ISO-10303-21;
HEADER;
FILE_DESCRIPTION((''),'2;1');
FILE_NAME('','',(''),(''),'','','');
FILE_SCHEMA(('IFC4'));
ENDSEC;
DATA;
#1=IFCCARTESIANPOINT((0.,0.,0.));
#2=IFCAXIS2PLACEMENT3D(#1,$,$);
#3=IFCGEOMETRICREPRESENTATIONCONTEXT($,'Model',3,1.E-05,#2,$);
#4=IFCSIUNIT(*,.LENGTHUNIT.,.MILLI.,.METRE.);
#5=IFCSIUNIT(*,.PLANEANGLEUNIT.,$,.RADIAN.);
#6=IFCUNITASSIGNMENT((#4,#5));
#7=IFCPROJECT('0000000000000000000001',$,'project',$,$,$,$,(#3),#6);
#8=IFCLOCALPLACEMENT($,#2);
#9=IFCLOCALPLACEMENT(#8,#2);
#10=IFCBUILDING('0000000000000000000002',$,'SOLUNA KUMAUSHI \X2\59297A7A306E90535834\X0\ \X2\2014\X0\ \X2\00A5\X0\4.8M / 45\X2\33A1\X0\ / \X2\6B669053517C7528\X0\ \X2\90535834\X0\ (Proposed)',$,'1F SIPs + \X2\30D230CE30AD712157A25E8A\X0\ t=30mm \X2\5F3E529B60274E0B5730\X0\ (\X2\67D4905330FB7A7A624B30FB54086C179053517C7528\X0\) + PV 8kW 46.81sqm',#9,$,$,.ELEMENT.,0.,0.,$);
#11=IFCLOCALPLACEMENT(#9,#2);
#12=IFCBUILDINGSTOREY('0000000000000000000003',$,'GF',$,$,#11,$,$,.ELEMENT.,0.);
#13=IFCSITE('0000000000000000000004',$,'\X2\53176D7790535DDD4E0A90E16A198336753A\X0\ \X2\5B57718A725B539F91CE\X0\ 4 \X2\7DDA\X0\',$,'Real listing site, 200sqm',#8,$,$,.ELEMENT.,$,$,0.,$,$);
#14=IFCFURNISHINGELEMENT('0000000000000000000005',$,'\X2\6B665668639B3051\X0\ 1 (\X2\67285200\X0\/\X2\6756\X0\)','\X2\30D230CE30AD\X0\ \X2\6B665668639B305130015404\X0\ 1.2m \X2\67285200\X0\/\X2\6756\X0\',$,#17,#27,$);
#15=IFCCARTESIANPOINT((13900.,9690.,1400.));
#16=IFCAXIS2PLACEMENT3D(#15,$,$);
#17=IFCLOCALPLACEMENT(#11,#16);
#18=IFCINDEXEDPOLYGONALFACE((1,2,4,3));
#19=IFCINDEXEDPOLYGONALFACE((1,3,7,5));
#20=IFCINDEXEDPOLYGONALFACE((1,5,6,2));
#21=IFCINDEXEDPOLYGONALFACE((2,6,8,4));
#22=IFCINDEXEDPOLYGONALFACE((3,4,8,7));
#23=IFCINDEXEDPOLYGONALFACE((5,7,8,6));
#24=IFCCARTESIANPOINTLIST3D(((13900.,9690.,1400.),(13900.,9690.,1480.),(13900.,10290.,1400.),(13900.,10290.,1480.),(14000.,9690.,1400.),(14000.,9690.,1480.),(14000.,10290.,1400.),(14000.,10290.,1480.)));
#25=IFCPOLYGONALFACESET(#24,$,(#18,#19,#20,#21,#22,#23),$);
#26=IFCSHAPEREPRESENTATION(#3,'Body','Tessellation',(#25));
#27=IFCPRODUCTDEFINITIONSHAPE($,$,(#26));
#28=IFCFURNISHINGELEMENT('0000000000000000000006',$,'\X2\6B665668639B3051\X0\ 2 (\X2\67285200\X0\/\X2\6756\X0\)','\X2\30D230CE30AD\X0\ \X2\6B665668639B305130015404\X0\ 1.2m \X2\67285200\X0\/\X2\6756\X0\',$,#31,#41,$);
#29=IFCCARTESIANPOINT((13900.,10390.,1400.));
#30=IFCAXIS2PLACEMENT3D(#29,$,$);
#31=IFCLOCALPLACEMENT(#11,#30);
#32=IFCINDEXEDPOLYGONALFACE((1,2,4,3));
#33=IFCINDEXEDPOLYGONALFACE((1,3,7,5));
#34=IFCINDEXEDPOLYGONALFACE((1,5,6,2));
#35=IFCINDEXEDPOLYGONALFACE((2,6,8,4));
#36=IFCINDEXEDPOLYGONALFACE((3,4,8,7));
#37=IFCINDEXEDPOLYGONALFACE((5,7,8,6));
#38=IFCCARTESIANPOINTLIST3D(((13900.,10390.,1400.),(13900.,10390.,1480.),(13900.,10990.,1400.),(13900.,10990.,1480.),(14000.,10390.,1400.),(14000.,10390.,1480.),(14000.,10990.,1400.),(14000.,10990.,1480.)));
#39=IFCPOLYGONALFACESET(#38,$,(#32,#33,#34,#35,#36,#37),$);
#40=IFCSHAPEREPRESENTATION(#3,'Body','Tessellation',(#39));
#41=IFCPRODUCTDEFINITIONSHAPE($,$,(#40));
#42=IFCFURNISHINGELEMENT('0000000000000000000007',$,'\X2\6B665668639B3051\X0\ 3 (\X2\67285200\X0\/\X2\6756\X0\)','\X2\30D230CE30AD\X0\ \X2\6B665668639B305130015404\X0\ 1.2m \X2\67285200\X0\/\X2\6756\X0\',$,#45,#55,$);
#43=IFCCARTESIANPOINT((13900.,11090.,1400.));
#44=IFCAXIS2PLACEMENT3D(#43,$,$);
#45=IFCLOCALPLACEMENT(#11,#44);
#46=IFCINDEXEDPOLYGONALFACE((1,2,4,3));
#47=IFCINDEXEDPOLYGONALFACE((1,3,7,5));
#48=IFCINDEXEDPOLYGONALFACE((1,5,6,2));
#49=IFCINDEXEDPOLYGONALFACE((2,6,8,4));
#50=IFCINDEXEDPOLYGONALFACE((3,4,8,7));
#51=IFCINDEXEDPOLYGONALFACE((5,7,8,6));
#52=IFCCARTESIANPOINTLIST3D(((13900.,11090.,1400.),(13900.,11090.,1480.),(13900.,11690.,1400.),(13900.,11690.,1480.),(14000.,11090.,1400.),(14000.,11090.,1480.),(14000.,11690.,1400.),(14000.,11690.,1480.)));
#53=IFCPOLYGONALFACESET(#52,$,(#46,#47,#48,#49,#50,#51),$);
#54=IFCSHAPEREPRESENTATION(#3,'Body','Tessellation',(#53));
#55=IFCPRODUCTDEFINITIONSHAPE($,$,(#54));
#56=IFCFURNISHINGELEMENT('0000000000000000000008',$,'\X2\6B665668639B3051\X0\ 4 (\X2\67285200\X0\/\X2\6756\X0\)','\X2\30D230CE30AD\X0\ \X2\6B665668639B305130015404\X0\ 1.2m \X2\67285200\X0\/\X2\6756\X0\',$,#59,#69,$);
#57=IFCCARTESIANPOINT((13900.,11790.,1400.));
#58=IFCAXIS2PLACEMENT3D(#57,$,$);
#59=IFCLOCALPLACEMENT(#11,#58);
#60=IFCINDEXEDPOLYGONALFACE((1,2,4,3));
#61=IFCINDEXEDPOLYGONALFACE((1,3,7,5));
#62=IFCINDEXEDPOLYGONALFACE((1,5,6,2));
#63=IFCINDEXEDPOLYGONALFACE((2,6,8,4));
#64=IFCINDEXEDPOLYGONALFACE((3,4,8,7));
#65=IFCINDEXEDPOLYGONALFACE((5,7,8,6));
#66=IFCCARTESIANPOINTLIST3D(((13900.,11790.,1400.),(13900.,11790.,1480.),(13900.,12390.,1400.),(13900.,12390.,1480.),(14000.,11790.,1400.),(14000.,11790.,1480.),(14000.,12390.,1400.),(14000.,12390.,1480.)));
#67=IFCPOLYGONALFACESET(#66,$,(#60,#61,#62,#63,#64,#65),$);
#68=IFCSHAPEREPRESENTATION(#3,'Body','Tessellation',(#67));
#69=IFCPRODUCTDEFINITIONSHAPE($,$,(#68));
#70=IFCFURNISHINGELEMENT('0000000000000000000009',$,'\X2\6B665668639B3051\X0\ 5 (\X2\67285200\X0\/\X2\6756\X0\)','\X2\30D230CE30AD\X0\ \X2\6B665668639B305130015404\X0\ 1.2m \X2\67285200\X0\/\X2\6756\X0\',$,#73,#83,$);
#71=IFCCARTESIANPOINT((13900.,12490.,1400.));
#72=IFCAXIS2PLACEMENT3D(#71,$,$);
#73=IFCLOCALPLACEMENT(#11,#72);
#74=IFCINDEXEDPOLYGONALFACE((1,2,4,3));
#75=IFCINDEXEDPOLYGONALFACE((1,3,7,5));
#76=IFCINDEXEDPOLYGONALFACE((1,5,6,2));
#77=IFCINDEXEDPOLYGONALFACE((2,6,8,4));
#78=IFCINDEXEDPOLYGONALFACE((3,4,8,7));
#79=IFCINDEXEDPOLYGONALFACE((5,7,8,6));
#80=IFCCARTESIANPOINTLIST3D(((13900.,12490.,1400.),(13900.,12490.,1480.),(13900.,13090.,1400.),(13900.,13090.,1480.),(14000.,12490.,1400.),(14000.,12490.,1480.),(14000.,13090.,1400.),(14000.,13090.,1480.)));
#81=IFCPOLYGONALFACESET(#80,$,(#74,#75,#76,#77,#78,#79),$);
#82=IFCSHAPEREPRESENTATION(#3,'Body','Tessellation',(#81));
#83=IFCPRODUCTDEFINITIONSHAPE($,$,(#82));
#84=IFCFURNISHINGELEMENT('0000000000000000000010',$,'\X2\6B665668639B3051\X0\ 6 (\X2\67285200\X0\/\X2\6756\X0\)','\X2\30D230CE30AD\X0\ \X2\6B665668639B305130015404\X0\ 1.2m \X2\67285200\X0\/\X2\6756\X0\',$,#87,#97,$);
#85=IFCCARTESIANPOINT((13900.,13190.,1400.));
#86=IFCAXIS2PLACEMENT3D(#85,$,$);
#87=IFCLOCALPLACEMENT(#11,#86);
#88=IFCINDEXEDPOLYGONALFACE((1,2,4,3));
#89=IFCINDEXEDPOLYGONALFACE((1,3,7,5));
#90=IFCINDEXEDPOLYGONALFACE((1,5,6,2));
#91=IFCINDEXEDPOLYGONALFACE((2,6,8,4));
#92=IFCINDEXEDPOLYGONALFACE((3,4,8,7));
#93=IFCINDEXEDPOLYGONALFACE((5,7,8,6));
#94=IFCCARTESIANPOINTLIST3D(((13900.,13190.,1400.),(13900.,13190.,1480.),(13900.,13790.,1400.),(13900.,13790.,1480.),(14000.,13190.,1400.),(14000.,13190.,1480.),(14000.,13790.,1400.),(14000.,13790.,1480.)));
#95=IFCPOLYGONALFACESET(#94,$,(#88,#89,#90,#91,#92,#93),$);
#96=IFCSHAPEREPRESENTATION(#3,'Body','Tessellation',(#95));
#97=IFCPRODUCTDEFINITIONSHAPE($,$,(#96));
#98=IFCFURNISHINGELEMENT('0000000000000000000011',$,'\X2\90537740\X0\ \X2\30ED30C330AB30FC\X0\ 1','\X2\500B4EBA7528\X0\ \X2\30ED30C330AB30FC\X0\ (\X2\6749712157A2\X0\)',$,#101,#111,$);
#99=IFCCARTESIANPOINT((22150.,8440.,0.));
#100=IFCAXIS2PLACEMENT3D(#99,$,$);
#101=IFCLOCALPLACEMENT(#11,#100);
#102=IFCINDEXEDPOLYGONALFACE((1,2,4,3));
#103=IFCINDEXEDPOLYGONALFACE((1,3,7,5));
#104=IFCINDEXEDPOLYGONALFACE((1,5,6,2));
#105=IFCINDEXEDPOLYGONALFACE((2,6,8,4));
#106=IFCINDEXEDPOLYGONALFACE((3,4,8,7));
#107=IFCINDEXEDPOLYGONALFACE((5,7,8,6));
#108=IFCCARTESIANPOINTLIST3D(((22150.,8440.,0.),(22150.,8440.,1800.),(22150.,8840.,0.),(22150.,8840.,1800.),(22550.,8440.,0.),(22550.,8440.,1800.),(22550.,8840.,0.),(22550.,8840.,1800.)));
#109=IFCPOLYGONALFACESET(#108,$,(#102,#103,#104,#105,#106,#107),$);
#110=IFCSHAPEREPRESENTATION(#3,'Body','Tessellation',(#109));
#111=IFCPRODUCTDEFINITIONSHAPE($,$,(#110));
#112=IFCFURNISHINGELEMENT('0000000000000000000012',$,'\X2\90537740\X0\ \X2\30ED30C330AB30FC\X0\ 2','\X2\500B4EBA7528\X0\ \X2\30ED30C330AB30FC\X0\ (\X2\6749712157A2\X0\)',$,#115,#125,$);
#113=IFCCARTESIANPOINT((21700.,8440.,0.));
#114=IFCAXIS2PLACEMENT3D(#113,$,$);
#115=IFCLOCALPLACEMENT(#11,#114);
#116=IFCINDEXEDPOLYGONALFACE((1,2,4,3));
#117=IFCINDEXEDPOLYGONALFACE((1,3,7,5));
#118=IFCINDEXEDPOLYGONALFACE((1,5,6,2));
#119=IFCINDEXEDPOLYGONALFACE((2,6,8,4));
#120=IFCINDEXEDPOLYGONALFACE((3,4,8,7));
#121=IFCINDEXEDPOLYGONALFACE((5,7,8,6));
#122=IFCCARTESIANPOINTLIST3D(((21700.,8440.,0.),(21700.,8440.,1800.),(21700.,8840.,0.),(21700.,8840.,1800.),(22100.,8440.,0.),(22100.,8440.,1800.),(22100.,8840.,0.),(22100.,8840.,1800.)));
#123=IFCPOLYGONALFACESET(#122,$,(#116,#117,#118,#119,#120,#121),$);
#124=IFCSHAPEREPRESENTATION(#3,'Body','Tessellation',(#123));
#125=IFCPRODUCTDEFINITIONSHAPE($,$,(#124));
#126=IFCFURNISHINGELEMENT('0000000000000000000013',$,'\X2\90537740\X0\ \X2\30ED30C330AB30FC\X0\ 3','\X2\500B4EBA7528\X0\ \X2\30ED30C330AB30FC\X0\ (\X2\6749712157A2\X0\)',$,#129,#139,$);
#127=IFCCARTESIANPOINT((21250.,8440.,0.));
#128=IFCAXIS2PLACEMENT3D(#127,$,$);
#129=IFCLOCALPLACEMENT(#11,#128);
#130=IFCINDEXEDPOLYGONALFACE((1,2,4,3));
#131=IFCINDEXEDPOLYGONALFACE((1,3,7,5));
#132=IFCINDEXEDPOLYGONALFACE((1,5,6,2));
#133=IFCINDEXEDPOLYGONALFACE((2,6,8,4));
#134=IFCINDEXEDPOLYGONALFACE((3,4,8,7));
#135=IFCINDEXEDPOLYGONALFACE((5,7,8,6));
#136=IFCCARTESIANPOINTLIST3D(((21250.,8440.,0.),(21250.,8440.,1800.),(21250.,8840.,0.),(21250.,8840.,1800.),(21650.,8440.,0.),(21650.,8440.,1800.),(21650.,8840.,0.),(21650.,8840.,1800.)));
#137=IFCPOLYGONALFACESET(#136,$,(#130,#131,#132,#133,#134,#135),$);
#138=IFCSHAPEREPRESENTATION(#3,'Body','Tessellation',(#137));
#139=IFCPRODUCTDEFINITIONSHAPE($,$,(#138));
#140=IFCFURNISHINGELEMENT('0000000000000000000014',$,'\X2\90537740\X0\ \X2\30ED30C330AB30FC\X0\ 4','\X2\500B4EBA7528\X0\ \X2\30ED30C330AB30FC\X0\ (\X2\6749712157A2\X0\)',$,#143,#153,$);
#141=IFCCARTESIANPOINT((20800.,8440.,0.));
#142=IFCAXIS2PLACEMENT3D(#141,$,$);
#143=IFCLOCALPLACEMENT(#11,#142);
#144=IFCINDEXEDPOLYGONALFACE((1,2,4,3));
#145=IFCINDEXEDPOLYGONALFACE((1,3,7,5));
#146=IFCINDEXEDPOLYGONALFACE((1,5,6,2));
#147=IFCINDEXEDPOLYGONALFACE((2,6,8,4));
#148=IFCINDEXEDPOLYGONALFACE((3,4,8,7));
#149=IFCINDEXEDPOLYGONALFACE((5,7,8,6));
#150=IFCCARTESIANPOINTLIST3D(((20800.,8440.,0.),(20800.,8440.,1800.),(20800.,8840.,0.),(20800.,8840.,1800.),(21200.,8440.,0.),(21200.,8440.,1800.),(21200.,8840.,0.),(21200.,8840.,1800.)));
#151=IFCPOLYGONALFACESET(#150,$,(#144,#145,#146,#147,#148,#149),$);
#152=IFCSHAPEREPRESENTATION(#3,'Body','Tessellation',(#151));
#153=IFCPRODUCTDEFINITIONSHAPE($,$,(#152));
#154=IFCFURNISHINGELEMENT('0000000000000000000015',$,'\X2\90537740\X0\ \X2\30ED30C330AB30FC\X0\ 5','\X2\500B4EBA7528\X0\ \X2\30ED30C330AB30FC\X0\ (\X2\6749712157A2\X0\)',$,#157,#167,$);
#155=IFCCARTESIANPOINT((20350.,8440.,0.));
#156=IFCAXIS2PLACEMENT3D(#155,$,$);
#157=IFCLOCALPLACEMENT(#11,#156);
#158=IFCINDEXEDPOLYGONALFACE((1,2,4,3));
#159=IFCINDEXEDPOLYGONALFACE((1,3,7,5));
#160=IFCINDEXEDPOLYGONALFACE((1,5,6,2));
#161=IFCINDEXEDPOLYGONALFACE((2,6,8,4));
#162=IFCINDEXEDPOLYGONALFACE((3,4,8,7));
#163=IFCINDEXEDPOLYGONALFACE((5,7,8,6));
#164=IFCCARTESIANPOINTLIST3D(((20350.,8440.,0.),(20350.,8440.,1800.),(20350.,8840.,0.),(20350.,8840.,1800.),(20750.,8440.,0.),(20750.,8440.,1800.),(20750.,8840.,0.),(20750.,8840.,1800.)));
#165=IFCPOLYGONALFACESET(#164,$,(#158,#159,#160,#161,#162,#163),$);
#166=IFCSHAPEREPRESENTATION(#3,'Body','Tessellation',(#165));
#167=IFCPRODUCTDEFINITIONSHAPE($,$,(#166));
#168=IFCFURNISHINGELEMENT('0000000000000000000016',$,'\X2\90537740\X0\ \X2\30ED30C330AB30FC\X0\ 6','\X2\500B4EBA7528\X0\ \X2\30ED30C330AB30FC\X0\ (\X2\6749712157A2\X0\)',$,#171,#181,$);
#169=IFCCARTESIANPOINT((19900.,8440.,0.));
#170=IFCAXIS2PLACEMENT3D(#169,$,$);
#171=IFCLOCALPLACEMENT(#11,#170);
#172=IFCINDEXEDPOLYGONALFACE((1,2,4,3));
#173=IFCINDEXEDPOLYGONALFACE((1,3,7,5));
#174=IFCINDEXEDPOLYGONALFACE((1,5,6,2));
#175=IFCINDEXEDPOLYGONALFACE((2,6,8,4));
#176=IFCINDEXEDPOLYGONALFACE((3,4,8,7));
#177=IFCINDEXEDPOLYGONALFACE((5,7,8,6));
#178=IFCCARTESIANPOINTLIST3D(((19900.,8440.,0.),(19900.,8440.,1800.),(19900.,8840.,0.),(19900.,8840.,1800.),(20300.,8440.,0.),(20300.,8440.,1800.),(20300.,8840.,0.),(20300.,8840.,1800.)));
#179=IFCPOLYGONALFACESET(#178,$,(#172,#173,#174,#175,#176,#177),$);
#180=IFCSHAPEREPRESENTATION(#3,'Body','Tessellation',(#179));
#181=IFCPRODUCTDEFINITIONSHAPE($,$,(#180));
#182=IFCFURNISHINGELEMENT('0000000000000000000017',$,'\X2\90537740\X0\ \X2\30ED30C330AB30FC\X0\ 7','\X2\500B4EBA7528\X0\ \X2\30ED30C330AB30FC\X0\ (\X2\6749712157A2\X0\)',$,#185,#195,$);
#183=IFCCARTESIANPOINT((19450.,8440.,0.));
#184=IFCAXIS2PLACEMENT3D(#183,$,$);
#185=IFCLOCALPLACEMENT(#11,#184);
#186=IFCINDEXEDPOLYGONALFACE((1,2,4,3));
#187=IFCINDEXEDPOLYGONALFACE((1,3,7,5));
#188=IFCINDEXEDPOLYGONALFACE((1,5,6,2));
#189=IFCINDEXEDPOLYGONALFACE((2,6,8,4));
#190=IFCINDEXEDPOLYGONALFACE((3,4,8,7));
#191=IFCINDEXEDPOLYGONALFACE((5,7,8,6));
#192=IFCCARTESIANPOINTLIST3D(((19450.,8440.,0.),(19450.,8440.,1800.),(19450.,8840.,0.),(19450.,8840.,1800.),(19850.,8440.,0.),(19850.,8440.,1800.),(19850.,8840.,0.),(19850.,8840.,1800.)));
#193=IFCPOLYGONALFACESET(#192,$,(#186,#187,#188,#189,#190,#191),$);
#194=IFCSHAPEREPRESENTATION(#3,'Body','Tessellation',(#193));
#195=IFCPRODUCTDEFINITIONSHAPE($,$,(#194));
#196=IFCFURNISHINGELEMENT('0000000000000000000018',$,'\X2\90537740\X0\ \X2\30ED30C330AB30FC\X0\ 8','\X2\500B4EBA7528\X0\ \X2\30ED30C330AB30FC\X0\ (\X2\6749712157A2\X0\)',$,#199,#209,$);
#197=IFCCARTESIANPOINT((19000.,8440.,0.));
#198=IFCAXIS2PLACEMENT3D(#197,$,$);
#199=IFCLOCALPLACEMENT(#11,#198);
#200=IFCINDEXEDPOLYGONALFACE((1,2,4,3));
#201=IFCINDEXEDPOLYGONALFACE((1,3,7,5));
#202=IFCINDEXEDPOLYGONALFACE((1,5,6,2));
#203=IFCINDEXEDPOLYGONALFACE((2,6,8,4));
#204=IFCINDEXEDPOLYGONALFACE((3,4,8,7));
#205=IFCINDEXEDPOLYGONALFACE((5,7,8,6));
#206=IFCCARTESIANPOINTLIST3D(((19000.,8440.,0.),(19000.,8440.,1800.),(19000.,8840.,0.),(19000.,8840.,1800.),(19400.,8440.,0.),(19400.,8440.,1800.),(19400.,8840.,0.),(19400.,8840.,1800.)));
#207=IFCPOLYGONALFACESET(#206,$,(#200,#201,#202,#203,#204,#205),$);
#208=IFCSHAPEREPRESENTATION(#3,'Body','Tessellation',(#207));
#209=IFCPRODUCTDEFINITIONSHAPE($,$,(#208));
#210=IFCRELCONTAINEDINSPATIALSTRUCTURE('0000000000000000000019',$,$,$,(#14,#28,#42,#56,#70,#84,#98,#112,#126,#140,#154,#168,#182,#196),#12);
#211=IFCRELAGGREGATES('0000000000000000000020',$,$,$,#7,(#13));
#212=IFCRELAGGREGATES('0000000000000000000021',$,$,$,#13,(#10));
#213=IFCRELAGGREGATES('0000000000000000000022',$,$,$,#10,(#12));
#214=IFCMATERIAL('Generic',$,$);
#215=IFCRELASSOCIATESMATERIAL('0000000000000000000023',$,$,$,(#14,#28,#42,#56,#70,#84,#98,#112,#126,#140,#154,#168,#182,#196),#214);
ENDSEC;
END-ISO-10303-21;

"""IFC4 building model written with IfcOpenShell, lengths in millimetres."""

from ifc_helpers import new_model, si_unit, frame, frame_2d, origin, place, context, project, spatial, rectangle, extrude, material, element, save


model = new_model("IFC4")

# Units and contexts
model_context = context("Model", 3, precision=1e-05, world=origin())
ifc_project = project(units=[si_unit("LENGTHUNIT", "METRE", prefix="MILLI"), si_unit("PLANEANGLEUNIT", "RADIAN")], contexts=[model_context])

# Site, building, storey
site_placement = place(None, origin())
site = spatial("IfcSite", under=ifc_project, at=site_placement, Name="北海道川上郡標茶町 字熊牛原野 4 線", ObjectType="Real listing site, 200sqm", CompositionType="ELEMENT", RefElevation=0.0)
building_placement = place(site_placement, origin())
building = spatial("IfcBuilding", under=site, at=building_placement, Name="SOLUNA KUMAUSHI 天空の道場 — ¥4.8M / 45㎡ / 武道兼用 道場 (Proposed)", ObjectType="1F SIPs + ヒノキ無垢床 t=30mm 弾力性下地 (柔道・空手・合気道兼用) + PV 8kW 46.81sqm", CompositionType="ELEMENT", ElevationOfRefHeight=0.0, ElevationOfTerrain=0.0)
storey_placement = place(building_placement, origin())
storey = spatial("IfcBuildingStorey", under=building, at=storey_placement, Name="GF", CompositionType="ELEMENT", Elevation=0.0)

# Shared definitions
ifc_material = material(Name="Generic")

# Furnishing elements
furnishing_1_placement = place(storey_placement, frame((13900.0, 9690.0, 1400.0)))
element("IfcFurnishingElement", 1, at=furnishing_1_placement, inside=storey, material=ifc_material, Name="武器掛け 1 (木刀/杖)", Description="ヒノキ 武器掛け、各 1.2m 木刀/杖", context=model_context, shape_type="SweptSolid", body=[
    extrude(rectangle(XDim=100.0, YDim=600.0, at=frame_2d((50.0, 300.0))), frame((13900.0, 9690.0, 1400.0)), (0.0, 0.0, 1.0), 80.0),
])
furnishing_2_placement = place(storey_placement, frame((13900.0, 10390.0, 1400.0)))
element("IfcFurnishingElement", 2, at=furnishing_2_placement, inside=storey, material=ifc_material, Name="武器掛け 2 (木刀/杖)", Description="ヒノキ 武器掛け、各 1.2m 木刀/杖", context=model_context, shape_type="SweptSolid", body=[
    extrude(rectangle(XDim=100.0, YDim=600.0, at=frame_2d((50.0, 300.0))), frame((13900.0, 10390.0, 1400.0)), (0.0, 0.0, 1.0), 80.0),
])
furnishing_3_placement = place(storey_placement, frame((13900.0, 11090.0, 1400.0)))
element("IfcFurnishingElement", 3, at=furnishing_3_placement, inside=storey, material=ifc_material, Name="武器掛け 3 (木刀/杖)", Description="ヒノキ 武器掛け、各 1.2m 木刀/杖", context=model_context, shape_type="SweptSolid", body=[
    extrude(rectangle(XDim=100.0, YDim=600.0, at=frame_2d((50.0, 300.0))), frame((13900.0, 11090.0, 1400.0)), (0.0, 0.0, 1.0), 80.0),
])
furnishing_4_placement = place(storey_placement, frame((13900.0, 11790.0, 1400.0)))
element("IfcFurnishingElement", 4, at=furnishing_4_placement, inside=storey, material=ifc_material, Name="武器掛け 4 (木刀/杖)", Description="ヒノキ 武器掛け、各 1.2m 木刀/杖", context=model_context, shape_type="SweptSolid", body=[
    extrude(rectangle(XDim=100.0, YDim=600.0, at=frame_2d((50.0, 300.0))), frame((13900.0, 11790.0, 1400.0)), (0.0, 0.0, 1.0), 80.0),
])
furnishing_5_placement = place(storey_placement, frame((13900.0, 12490.0, 1400.0)))
element("IfcFurnishingElement", 5, at=furnishing_5_placement, inside=storey, material=ifc_material, Name="武器掛け 5 (木刀/杖)", Description="ヒノキ 武器掛け、各 1.2m 木刀/杖", context=model_context, shape_type="SweptSolid", body=[
    extrude(rectangle(XDim=100.0, YDim=600.0, at=frame_2d((50.0, 300.0))), frame((13900.0, 12490.0, 1400.0)), (0.0, 0.0, 1.0), 80.0),
])
furnishing_6_placement = place(storey_placement, frame((13900.0, 13190.0, 1400.0)))
element("IfcFurnishingElement", 6, at=furnishing_6_placement, inside=storey, material=ifc_material, Name="武器掛け 6 (木刀/杖)", Description="ヒノキ 武器掛け、各 1.2m 木刀/杖", context=model_context, shape_type="SweptSolid", body=[
    extrude(rectangle(XDim=100.0, YDim=600.0, at=frame_2d((50.0, 300.0))), frame((13900.0, 13190.0, 1400.0)), (0.0, 0.0, 1.0), 80.0),
])
furnishing_7_placement = place(storey_placement, frame((22150.0, 8440.0, 0.0)))
element("IfcFurnishingElement", 7, at=furnishing_7_placement, inside=storey, material=ifc_material, Name="道着 ロッカー 1", Description="個人用 ロッカー (杉無垢)", context=model_context, shape_type="SweptSolid", body=[
    extrude(rectangle(XDim=400.0, YDim=400.0, at=frame_2d((200.0, 200.0))), frame((22150.0, 8440.0, 0.0)), (0.0, 0.0, 1.0), 1800.0),
])
furnishing_8_placement = place(storey_placement, frame((21700.0, 8440.0, 0.0)))
element("IfcFurnishingElement", 8, at=furnishing_8_placement, inside=storey, material=ifc_material, Name="道着 ロッカー 2", Description="個人用 ロッカー (杉無垢)", context=model_context, shape_type="SweptSolid", body=[
    extrude(rectangle(XDim=400.0, YDim=400.0, at=frame_2d((200.0, 200.0))), frame((21700.0, 8440.0, 0.0)), (0.0, 0.0, 1.0), 1800.0),
])
furnishing_9_placement = place(storey_placement, frame((21250.0, 8440.0, 0.0)))
element("IfcFurnishingElement", 9, at=furnishing_9_placement, inside=storey, material=ifc_material, Name="道着 ロッカー 3", Description="個人用 ロッカー (杉無垢)", context=model_context, shape_type="SweptSolid", body=[
    extrude(rectangle(XDim=400.0, YDim=400.0, at=frame_2d((200.0, 200.0))), frame((21250.0, 8440.0, 0.0)), (0.0, 0.0, 1.0), 1800.0),
])
furnishing_10_placement = place(storey_placement, frame((20800.0, 8440.0, 0.0)))
element("IfcFurnishingElement", 10, at=furnishing_10_placement, inside=storey, material=ifc_material, Name="道着 ロッカー 4", Description="個人用 ロッカー (杉無垢)", context=model_context, shape_type="SweptSolid", body=[
    extrude(rectangle(XDim=400.0, YDim=400.0, at=frame_2d((200.0, 200.0))), frame((20800.0, 8440.0, 0.0)), (0.0, 0.0, 1.0), 1800.0),
])
furnishing_11_placement = place(storey_placement, frame((20350.0, 8440.0, 0.0)))
element("IfcFurnishingElement", 11, at=furnishing_11_placement, inside=storey, material=ifc_material, Name="道着 ロッカー 5", Description="個人用 ロッカー (杉無垢)", context=model_context, shape_type="SweptSolid", body=[
    extrude(rectangle(XDim=400.0, YDim=400.0, at=frame_2d((200.0, 200.0))), frame((20350.0, 8440.0, 0.0)), (0.0, 0.0, 1.0), 1800.0),
])
furnishing_12_placement = place(storey_placement, frame((19900.0, 8440.0, 0.0)))
element("IfcFurnishingElement", 12, at=furnishing_12_placement, inside=storey, material=ifc_material, Name="道着 ロッカー 6", Description="個人用 ロッカー (杉無垢)", context=model_context, shape_type="SweptSolid", body=[
    extrude(rectangle(XDim=400.0, YDim=400.0, at=frame_2d((200.0, 200.0))), frame((19900.0, 8440.0, 0.0)), (0.0, 0.0, 1.0), 1800.0),
])
furnishing_13_placement = place(storey_placement, frame((19450.0, 8440.0, 0.0)))
element("IfcFurnishingElement", 13, at=furnishing_13_placement, inside=storey, material=ifc_material, Name="道着 ロッカー 7", Description="個人用 ロッカー (杉無垢)", context=model_context, shape_type="SweptSolid", body=[
    extrude(rectangle(XDim=400.0, YDim=400.0, at=frame_2d((200.0, 200.0))), frame((19450.0, 8440.0, 0.0)), (0.0, 0.0, 1.0), 1800.0),
])
furnishing_14_placement = place(storey_placement, frame((19000.0, 8440.0, 0.0)))
element("IfcFurnishingElement", 14, at=furnishing_14_placement, inside=storey, material=ifc_material, Name="道着 ロッカー 8", Description="個人用 ロッカー (杉無垢)", context=model_context, shape_type="SweptSolid", body=[
    extrude(rectangle(XDim=400.0, YDim=400.0, at=frame_2d((200.0, 200.0))), frame((19000.0, 8440.0, 0.0)), (0.0, 0.0, 1.0), 1800.0),
])

save(model, "model.ifc")
